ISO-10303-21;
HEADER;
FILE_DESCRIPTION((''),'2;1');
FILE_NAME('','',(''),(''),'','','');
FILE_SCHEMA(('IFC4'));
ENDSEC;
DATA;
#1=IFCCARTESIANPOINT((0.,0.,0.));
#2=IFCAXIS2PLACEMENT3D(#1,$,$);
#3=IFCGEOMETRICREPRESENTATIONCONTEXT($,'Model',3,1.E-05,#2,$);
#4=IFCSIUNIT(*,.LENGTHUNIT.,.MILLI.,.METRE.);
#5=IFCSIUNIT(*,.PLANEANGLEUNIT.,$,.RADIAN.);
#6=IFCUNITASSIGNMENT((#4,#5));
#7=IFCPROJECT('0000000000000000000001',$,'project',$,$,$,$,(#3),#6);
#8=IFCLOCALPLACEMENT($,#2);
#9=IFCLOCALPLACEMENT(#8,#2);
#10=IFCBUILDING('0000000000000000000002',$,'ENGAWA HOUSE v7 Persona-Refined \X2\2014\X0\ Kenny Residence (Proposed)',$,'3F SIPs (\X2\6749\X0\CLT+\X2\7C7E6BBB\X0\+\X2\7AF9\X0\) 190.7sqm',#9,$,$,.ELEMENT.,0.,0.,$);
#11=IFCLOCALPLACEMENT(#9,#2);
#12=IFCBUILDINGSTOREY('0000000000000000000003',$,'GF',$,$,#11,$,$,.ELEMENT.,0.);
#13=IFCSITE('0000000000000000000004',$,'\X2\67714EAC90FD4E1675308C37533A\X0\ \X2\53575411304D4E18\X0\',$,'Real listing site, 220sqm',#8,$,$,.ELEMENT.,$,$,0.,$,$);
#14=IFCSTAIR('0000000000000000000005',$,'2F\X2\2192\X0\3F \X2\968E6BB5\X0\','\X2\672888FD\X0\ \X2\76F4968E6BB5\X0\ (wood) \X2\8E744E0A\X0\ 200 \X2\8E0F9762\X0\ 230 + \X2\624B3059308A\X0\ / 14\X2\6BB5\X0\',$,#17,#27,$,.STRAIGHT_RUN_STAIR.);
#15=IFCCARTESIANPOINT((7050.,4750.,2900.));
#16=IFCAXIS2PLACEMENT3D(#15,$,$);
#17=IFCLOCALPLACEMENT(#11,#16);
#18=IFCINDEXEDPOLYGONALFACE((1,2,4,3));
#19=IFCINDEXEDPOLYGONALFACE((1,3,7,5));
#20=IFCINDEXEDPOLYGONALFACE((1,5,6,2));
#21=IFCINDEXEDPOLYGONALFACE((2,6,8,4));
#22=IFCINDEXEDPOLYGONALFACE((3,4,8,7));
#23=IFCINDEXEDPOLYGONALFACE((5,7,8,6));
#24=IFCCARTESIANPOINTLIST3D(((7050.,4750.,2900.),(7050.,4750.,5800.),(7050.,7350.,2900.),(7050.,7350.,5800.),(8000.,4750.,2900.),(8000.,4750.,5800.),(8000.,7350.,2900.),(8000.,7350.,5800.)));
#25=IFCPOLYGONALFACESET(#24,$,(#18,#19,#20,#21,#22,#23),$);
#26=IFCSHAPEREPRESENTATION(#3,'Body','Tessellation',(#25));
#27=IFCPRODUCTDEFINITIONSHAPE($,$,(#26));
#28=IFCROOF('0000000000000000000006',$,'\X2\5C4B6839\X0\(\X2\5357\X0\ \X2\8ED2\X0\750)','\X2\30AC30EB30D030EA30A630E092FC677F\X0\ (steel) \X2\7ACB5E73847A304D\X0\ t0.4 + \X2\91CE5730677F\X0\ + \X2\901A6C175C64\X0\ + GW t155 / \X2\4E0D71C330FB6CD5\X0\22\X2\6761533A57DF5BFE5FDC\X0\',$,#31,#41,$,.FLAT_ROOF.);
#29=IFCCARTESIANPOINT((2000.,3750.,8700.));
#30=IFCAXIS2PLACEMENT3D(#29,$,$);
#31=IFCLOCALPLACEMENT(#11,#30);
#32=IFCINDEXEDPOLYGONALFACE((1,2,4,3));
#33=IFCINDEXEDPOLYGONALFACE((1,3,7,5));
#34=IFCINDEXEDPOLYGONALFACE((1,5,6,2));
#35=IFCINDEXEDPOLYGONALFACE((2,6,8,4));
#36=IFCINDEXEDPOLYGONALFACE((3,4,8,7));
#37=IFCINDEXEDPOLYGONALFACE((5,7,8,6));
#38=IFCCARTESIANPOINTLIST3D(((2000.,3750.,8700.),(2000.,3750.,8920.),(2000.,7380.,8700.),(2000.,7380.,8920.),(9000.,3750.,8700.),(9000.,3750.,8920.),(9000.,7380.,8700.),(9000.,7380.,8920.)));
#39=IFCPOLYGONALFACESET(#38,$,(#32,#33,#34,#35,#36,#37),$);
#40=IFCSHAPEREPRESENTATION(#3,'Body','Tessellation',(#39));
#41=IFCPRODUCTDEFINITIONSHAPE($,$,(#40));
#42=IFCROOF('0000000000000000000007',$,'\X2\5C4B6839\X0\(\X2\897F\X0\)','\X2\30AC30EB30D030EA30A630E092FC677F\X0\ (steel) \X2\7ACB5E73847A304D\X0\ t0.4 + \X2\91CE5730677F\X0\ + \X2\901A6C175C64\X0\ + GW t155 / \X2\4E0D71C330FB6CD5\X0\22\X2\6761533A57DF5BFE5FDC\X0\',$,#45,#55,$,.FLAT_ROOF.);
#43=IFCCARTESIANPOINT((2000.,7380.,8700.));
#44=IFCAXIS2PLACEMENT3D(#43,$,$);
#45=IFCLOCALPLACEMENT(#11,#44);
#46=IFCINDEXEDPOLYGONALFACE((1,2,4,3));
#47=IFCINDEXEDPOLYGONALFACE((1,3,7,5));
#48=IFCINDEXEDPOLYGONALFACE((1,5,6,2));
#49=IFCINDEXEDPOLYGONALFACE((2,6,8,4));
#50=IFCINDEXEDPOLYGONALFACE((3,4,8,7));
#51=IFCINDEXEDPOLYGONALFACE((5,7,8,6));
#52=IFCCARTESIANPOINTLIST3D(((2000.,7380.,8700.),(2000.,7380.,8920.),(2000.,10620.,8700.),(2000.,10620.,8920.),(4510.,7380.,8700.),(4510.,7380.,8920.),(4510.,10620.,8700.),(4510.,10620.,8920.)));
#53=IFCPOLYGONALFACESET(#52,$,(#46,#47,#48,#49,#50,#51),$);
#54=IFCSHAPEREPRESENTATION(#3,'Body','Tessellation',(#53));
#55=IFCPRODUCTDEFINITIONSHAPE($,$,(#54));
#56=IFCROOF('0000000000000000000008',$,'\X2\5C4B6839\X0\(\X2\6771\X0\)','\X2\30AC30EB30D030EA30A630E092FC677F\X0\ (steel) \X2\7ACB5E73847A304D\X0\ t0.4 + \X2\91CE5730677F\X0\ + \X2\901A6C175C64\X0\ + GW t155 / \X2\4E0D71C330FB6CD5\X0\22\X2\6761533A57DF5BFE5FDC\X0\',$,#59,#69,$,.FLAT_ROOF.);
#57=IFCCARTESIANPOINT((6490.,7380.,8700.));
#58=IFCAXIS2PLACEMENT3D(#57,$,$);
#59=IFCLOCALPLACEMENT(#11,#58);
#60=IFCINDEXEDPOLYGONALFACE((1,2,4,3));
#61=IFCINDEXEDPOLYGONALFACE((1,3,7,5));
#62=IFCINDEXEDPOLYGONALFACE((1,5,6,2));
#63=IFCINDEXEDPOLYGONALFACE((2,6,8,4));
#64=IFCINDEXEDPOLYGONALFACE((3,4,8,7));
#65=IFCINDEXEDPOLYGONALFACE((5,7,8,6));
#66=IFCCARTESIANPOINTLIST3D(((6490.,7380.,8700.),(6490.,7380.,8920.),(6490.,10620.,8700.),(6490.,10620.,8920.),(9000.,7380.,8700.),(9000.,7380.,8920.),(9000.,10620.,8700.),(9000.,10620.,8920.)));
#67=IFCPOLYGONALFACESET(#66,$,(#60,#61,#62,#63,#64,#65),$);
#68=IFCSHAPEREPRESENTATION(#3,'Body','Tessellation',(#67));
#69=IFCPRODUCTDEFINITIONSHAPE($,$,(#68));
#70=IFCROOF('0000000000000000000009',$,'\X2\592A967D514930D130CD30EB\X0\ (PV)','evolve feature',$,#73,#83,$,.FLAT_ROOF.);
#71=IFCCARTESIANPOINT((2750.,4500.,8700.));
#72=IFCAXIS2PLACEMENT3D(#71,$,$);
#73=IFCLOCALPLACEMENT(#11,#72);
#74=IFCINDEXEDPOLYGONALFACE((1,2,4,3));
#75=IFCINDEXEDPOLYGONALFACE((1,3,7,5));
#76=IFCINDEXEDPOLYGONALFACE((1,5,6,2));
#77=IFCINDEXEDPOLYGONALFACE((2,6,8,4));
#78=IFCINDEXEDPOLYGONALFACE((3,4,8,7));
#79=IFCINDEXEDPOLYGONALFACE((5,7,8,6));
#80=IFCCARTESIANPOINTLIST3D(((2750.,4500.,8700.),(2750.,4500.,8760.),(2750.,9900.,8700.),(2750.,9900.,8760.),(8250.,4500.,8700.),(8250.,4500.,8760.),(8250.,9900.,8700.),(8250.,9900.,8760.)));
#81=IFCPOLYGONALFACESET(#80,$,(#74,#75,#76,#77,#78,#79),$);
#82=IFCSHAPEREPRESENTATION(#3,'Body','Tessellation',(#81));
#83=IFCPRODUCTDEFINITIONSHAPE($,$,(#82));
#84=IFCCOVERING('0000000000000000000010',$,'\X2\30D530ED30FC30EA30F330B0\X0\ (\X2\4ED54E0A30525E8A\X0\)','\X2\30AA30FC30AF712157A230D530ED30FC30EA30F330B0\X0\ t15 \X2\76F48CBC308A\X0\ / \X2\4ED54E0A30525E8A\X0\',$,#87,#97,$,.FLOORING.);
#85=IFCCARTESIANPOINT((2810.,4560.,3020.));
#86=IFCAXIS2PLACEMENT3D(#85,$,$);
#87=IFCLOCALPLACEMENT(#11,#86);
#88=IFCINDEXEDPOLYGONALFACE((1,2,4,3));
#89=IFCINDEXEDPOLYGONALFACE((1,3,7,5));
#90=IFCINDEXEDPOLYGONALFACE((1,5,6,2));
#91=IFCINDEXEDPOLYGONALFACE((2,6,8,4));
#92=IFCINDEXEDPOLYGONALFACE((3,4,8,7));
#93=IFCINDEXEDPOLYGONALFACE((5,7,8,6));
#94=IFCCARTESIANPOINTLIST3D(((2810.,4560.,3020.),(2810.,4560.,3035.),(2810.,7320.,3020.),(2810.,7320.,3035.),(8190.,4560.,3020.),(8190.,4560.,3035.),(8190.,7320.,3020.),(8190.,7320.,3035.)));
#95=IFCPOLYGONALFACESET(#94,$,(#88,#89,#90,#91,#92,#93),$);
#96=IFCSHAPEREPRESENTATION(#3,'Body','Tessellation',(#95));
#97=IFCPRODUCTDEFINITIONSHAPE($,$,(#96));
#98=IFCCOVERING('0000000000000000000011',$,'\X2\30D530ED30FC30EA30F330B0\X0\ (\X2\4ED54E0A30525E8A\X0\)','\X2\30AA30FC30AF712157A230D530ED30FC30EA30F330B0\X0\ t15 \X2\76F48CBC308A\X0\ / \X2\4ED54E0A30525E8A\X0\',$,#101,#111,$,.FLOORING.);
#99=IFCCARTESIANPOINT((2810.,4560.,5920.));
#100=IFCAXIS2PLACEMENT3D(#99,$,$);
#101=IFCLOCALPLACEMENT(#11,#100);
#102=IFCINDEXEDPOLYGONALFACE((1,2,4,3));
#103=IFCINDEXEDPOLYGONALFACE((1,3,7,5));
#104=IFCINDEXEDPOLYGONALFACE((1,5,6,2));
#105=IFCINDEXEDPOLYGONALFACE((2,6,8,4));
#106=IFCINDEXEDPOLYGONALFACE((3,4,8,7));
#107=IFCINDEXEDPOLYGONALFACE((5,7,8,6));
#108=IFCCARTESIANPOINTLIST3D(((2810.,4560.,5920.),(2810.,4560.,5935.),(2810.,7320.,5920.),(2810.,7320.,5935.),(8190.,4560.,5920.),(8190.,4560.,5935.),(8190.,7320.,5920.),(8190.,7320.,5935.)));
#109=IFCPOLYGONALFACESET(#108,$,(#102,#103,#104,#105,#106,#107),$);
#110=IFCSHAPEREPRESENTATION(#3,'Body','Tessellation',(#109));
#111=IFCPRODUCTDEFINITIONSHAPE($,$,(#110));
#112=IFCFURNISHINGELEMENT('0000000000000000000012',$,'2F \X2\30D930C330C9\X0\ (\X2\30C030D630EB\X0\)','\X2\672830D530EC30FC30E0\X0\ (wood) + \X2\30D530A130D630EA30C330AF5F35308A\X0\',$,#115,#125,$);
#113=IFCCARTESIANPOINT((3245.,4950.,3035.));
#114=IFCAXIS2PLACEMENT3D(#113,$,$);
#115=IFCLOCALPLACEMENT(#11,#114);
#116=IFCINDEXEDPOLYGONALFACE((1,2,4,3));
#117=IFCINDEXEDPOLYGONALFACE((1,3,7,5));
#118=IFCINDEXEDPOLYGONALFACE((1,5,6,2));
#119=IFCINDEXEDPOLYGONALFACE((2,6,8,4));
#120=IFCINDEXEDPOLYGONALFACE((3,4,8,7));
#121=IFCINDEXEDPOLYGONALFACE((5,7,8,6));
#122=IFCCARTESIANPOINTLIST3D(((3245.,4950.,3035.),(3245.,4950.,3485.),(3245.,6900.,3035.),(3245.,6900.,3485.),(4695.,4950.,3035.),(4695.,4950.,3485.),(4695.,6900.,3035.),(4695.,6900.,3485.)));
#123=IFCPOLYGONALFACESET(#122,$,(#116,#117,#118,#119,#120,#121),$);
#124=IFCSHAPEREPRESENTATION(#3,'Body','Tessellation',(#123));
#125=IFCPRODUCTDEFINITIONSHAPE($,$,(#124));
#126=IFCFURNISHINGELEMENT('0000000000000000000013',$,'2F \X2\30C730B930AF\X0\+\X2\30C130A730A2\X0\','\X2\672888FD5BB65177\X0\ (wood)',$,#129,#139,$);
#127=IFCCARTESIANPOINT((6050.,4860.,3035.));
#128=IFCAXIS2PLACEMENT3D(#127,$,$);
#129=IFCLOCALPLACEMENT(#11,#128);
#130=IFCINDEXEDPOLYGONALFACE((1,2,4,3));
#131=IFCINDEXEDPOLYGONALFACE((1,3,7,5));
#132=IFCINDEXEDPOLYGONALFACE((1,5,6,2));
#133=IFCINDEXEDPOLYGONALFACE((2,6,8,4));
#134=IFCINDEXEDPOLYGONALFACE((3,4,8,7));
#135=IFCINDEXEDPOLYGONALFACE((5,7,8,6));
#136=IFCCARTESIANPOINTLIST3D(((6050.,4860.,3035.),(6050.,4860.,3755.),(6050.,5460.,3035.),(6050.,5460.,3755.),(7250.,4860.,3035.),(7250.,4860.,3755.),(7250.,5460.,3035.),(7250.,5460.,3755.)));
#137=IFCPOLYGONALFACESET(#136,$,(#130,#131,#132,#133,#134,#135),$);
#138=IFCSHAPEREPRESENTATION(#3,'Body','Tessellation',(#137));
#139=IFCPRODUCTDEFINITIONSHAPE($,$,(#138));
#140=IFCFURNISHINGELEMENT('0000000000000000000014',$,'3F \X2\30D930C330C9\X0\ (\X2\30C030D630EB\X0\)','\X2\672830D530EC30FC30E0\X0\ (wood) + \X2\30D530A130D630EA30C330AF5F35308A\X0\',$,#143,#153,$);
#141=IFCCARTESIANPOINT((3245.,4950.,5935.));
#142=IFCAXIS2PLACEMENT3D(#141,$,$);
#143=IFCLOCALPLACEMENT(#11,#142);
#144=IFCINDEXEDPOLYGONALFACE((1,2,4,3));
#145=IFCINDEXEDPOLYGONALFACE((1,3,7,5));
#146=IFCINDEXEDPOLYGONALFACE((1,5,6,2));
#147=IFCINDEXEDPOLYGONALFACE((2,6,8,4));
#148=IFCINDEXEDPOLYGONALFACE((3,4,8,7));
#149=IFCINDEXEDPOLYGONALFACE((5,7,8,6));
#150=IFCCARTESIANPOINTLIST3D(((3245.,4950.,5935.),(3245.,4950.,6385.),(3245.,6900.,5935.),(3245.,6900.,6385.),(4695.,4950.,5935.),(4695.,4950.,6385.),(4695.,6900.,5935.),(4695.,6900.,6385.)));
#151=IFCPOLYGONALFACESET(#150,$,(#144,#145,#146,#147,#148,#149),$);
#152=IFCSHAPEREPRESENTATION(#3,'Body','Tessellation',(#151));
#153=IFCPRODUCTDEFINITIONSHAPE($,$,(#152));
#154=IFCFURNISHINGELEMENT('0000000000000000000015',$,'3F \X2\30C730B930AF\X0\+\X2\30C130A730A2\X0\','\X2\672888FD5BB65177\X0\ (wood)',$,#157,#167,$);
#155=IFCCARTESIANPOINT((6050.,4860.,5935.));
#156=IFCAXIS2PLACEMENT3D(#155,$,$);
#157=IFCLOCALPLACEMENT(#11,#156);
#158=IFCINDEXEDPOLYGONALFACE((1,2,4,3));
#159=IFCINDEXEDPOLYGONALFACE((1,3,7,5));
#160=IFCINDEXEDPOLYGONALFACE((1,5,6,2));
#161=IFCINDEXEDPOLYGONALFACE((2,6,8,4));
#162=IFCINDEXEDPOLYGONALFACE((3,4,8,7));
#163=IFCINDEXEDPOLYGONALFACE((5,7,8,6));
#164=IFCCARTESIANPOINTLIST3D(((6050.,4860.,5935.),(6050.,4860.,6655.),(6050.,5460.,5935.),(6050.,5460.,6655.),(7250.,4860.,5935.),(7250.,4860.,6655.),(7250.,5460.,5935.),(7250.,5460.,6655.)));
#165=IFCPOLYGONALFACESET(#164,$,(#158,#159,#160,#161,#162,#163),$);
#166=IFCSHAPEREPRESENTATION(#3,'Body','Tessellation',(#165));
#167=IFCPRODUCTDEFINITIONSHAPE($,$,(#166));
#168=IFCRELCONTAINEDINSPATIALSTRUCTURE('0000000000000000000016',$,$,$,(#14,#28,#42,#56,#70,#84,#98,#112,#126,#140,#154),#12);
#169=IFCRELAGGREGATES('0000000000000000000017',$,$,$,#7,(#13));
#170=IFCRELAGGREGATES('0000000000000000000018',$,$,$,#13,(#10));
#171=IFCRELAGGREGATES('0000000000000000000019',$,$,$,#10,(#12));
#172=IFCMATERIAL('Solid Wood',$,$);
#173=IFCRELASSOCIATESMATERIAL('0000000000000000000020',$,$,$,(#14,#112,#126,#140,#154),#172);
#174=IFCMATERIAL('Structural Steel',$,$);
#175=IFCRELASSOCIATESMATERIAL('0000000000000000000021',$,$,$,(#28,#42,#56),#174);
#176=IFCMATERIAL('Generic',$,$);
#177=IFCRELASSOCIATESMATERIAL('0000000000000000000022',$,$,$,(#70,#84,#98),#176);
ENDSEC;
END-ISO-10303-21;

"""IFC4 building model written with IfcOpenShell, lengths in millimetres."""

from ifc_helpers import new_model, si_unit, frame, frame_2d, origin, place, context, project, spatial, rectangle, extrude, material, element, save


model = new_model("IFC4")

# Units and contexts
model_context = context("Model", 3, precision=1e-05, world=origin())
ifc_project = project(units=[si_unit("LENGTHUNIT", "METRE", prefix="MILLI"), si_unit("PLANEANGLEUNIT", "RADIAN")], contexts=[model_context])

# Site, building, storey
site_placement = place(None, origin())
site = spatial("IfcSite", under=ifc_project, at=site_placement, Name="東京都世田谷区 南向き丘", ObjectType="Real listing site, 220sqm", CompositionType="ELEMENT", RefElevation=0.0)
building_placement = place(site_placement, origin())
building = spatial("IfcBuilding", under=site, at=building_placement, Name="ENGAWA HOUSE v7 Persona-Refined — Kenny Residence (Proposed)", ObjectType="3F SIPs (杉CLT+籾殻+竹) 190.7sqm", CompositionType="ELEMENT", ElevationOfRefHeight=0.0, ElevationOfTerrain=0.0)
storey_placement = place(building_placement, origin())
storey = spatial("IfcBuildingStorey", under=building, at=storey_placement, Name="GF", CompositionType="ELEMENT", Elevation=0.0)

# Shared definitions
ifc_material_1 = material(Name="Solid Wood")

# Stair
stair_placement = place(storey_placement, frame((7050.0, 4750.0, 2900.0)))
element("IfcStair", 1, at=stair_placement, inside=storey, material=ifc_material_1, Name="2F→3F 階段", Description="木製 直階段 (wood) 蹴上 200 踏面 230 + 手すり / 14段", PredefinedType="STRAIGHT_RUN_STAIR", context=model_context, shape_type="SweptSolid", body=[
    extrude(rectangle(XDim=950.0, YDim=2600.0, at=frame_2d((475.0, 1300.0))), frame((7050.0, 4750.0, 2900.0)), (0.0, 0.0, 1.0), 2900.0),
])

# Roofs
ifc_material_2 = material(Name="Structural Steel")
roof_1_placement = place(storey_placement, frame((2000.0, 3750.0, 8700.0)))
element("IfcRoof", 2, at=roof_1_placement, inside=storey, material=ifc_material_2, Name="屋根(南 軒750)", Description="ガルバリウム鋼板 (steel) 立平葺き t0.4 + 野地板 + 通気層 + GW t155 / 不燃・法22条区域対応", PredefinedType="FLAT_ROOF", context=model_context, shape_type="SweptSolid", body=[
    extrude(rectangle(XDim=7000.0, YDim=3630.0, at=frame_2d((3500.0, 1815.0))), frame((2000.0, 3750.0, 8700.0)), (0.0, 0.0, 1.0), 220.0),
])
roof_2_placement = place(storey_placement, frame((2000.0, 7380.0, 8700.0)))
element("IfcRoof", 3, at=roof_2_placement, inside=storey, material=ifc_material_2, Name="屋根(西)", Description="ガルバリウム鋼板 (steel) 立平葺き t0.4 + 野地板 + 通気層 + GW t155 / 不燃・法22条区域対応", PredefinedType="FLAT_ROOF", context=model_context, shape_type="SweptSolid", body=[
    extrude(rectangle(XDim=2510.0, YDim=3240.0, at=frame_2d((1255.0, 1620.0))), frame((2000.0, 7380.0, 8700.0)), (0.0, 0.0, 1.0), 220.0),
])
roof_3_placement = place(storey_placement, frame((6490.0, 7380.0, 8700.0)))
element("IfcRoof", 4, at=roof_3_placement, inside=storey, material=ifc_material_2, Name="屋根(東)", Description="ガルバリウム鋼板 (steel) 立平葺き t0.4 + 野地板 + 通気層 + GW t155 / 不燃・法22条区域対応", PredefinedType="FLAT_ROOF", context=model_context, shape_type="SweptSolid", body=[
    extrude(rectangle(XDim=2510.0, YDim=3240.0, at=frame_2d((1255.0, 1620.0))), frame((6490.0, 7380.0, 8700.0)), (0.0, 0.0, 1.0), 220.0),
])
ifc_material_3 = material(Name="Generic")
roof_4_placement = place(storey_placement, frame((2750.0, 4500.0, 8700.0)))
element("IfcRoof", 5, at=roof_4_placement, inside=storey, material=ifc_material_3, Name="太陽光パネル (PV)", Description="evolve feature", PredefinedType="FLAT_ROOF", context=model_context, shape_type="SweptSolid", body=[
    extrude(rectangle(XDim=5500.0, YDim=5400.0, at=frame_2d((2750.0, 2700.0))), frame((2750.0, 4500.0, 8700.0)), (0.0, 0.0, 1.0), 60.0),
])

# Coverings
covering_1_placement = place(storey_placement, frame((2810.0, 4560.0, 3020.0)))
element("IfcCovering", 6, at=covering_1_placement, inside=storey, material=ifc_material_3, Name="フローリング (仕上げ床)", Description="オーク無垢フローリング t15 直貼り / 仕上げ床", PredefinedType="FLOORING", context=model_context, shape_type="SweptSolid", body=[
    extrude(rectangle(XDim=5380.0, YDim=2760.0, at=frame_2d((2690.0, 1380.0))), frame((2810.0, 4560.0, 3020.0)), (0.0, 0.0, 1.0), 15.0),
])
covering_2_placement = place(storey_placement, frame((2810.0, 4560.0, 5920.0)))
element("IfcCovering", 7, at=covering_2_placement, inside=storey, material=ifc_material_3, Name="フローリング (仕上げ床)", Description="オーク無垢フローリング t15 直貼り / 仕上げ床", PredefinedType="FLOORING", context=model_context, shape_type="SweptSolid", body=[
    extrude(rectangle(XDim=5380.0, YDim=2760.0, at=frame_2d((2690.0, 1380.0))), frame((2810.0, 4560.0, 5920.0)), (0.0, 0.0, 1.0), 15.0),
])

# Furnishing elements
furnishing_1_placement = place(storey_placement, frame((3245.0, 4950.0, 3035.0)))
element("IfcFurnishingElement", 8, at=furnishing_1_placement, inside=storey, material=ifc_material_1, Name="2F ベッド (ダブル)", Description="木フレーム (wood) + ファブリック張り", context=model_context, shape_type="SweptSolid", body=[
    extrude(rectangle(XDim=1450.0, YDim=1950.0, at=frame_2d((725.0, 975.0))), frame((3245.0, 4950.0, 3035.0)), (0.0, 0.0, 1.0), 450.0),
])
furnishing_2_placement = place(storey_placement, frame((6050.0, 4860.0, 3035.0)))
element("IfcFurnishingElement", 9, at=furnishing_2_placement, inside=storey, material=ifc_material_1, Name="2F デスク+チェア", Description="木製家具 (wood)", context=model_context, shape_type="SweptSolid", body=[
    extrude(rectangle(XDim=1200.0, YDim=600.0, at=frame_2d((600.0, 300.0))), frame((6050.0, 4860.0, 3035.0)), (0.0, 0.0, 1.0), 720.0),
])
furnishing_3_placement = place(storey_placement, frame((3245.0, 4950.0, 5935.0)))
element("IfcFurnishingElement", 10, at=furnishing_3_placement, inside=storey, material=ifc_material_1, Name="3F ベッド (ダブル)", Description="木フレーム (wood) + ファブリック張り", context=model_context, shape_type="SweptSolid", body=[
    extrude(rectangle(XDim=1450.0, YDim=1950.0, at=frame_2d((725.0, 975.0))), frame((3245.0, 4950.0, 5935.0)), (0.0, 0.0, 1.0), 450.0),
])
furnishing_4_placement = place(storey_placement, frame((6050.0, 4860.0, 5935.0)))
element("IfcFurnishingElement", 11, at=furnishing_4_placement, inside=storey, material=ifc_material_1, Name="3F デスク+チェア", Description="木製家具 (wood)", context=model_context, shape_type="SweptSolid", body=[
    extrude(rectangle(XDim=1200.0, YDim=600.0, at=frame_2d((600.0, 300.0))), frame((6050.0, 4860.0, 5935.0)), (0.0, 0.0, 1.0), 720.0),
])

save(model, "model.ifc")
